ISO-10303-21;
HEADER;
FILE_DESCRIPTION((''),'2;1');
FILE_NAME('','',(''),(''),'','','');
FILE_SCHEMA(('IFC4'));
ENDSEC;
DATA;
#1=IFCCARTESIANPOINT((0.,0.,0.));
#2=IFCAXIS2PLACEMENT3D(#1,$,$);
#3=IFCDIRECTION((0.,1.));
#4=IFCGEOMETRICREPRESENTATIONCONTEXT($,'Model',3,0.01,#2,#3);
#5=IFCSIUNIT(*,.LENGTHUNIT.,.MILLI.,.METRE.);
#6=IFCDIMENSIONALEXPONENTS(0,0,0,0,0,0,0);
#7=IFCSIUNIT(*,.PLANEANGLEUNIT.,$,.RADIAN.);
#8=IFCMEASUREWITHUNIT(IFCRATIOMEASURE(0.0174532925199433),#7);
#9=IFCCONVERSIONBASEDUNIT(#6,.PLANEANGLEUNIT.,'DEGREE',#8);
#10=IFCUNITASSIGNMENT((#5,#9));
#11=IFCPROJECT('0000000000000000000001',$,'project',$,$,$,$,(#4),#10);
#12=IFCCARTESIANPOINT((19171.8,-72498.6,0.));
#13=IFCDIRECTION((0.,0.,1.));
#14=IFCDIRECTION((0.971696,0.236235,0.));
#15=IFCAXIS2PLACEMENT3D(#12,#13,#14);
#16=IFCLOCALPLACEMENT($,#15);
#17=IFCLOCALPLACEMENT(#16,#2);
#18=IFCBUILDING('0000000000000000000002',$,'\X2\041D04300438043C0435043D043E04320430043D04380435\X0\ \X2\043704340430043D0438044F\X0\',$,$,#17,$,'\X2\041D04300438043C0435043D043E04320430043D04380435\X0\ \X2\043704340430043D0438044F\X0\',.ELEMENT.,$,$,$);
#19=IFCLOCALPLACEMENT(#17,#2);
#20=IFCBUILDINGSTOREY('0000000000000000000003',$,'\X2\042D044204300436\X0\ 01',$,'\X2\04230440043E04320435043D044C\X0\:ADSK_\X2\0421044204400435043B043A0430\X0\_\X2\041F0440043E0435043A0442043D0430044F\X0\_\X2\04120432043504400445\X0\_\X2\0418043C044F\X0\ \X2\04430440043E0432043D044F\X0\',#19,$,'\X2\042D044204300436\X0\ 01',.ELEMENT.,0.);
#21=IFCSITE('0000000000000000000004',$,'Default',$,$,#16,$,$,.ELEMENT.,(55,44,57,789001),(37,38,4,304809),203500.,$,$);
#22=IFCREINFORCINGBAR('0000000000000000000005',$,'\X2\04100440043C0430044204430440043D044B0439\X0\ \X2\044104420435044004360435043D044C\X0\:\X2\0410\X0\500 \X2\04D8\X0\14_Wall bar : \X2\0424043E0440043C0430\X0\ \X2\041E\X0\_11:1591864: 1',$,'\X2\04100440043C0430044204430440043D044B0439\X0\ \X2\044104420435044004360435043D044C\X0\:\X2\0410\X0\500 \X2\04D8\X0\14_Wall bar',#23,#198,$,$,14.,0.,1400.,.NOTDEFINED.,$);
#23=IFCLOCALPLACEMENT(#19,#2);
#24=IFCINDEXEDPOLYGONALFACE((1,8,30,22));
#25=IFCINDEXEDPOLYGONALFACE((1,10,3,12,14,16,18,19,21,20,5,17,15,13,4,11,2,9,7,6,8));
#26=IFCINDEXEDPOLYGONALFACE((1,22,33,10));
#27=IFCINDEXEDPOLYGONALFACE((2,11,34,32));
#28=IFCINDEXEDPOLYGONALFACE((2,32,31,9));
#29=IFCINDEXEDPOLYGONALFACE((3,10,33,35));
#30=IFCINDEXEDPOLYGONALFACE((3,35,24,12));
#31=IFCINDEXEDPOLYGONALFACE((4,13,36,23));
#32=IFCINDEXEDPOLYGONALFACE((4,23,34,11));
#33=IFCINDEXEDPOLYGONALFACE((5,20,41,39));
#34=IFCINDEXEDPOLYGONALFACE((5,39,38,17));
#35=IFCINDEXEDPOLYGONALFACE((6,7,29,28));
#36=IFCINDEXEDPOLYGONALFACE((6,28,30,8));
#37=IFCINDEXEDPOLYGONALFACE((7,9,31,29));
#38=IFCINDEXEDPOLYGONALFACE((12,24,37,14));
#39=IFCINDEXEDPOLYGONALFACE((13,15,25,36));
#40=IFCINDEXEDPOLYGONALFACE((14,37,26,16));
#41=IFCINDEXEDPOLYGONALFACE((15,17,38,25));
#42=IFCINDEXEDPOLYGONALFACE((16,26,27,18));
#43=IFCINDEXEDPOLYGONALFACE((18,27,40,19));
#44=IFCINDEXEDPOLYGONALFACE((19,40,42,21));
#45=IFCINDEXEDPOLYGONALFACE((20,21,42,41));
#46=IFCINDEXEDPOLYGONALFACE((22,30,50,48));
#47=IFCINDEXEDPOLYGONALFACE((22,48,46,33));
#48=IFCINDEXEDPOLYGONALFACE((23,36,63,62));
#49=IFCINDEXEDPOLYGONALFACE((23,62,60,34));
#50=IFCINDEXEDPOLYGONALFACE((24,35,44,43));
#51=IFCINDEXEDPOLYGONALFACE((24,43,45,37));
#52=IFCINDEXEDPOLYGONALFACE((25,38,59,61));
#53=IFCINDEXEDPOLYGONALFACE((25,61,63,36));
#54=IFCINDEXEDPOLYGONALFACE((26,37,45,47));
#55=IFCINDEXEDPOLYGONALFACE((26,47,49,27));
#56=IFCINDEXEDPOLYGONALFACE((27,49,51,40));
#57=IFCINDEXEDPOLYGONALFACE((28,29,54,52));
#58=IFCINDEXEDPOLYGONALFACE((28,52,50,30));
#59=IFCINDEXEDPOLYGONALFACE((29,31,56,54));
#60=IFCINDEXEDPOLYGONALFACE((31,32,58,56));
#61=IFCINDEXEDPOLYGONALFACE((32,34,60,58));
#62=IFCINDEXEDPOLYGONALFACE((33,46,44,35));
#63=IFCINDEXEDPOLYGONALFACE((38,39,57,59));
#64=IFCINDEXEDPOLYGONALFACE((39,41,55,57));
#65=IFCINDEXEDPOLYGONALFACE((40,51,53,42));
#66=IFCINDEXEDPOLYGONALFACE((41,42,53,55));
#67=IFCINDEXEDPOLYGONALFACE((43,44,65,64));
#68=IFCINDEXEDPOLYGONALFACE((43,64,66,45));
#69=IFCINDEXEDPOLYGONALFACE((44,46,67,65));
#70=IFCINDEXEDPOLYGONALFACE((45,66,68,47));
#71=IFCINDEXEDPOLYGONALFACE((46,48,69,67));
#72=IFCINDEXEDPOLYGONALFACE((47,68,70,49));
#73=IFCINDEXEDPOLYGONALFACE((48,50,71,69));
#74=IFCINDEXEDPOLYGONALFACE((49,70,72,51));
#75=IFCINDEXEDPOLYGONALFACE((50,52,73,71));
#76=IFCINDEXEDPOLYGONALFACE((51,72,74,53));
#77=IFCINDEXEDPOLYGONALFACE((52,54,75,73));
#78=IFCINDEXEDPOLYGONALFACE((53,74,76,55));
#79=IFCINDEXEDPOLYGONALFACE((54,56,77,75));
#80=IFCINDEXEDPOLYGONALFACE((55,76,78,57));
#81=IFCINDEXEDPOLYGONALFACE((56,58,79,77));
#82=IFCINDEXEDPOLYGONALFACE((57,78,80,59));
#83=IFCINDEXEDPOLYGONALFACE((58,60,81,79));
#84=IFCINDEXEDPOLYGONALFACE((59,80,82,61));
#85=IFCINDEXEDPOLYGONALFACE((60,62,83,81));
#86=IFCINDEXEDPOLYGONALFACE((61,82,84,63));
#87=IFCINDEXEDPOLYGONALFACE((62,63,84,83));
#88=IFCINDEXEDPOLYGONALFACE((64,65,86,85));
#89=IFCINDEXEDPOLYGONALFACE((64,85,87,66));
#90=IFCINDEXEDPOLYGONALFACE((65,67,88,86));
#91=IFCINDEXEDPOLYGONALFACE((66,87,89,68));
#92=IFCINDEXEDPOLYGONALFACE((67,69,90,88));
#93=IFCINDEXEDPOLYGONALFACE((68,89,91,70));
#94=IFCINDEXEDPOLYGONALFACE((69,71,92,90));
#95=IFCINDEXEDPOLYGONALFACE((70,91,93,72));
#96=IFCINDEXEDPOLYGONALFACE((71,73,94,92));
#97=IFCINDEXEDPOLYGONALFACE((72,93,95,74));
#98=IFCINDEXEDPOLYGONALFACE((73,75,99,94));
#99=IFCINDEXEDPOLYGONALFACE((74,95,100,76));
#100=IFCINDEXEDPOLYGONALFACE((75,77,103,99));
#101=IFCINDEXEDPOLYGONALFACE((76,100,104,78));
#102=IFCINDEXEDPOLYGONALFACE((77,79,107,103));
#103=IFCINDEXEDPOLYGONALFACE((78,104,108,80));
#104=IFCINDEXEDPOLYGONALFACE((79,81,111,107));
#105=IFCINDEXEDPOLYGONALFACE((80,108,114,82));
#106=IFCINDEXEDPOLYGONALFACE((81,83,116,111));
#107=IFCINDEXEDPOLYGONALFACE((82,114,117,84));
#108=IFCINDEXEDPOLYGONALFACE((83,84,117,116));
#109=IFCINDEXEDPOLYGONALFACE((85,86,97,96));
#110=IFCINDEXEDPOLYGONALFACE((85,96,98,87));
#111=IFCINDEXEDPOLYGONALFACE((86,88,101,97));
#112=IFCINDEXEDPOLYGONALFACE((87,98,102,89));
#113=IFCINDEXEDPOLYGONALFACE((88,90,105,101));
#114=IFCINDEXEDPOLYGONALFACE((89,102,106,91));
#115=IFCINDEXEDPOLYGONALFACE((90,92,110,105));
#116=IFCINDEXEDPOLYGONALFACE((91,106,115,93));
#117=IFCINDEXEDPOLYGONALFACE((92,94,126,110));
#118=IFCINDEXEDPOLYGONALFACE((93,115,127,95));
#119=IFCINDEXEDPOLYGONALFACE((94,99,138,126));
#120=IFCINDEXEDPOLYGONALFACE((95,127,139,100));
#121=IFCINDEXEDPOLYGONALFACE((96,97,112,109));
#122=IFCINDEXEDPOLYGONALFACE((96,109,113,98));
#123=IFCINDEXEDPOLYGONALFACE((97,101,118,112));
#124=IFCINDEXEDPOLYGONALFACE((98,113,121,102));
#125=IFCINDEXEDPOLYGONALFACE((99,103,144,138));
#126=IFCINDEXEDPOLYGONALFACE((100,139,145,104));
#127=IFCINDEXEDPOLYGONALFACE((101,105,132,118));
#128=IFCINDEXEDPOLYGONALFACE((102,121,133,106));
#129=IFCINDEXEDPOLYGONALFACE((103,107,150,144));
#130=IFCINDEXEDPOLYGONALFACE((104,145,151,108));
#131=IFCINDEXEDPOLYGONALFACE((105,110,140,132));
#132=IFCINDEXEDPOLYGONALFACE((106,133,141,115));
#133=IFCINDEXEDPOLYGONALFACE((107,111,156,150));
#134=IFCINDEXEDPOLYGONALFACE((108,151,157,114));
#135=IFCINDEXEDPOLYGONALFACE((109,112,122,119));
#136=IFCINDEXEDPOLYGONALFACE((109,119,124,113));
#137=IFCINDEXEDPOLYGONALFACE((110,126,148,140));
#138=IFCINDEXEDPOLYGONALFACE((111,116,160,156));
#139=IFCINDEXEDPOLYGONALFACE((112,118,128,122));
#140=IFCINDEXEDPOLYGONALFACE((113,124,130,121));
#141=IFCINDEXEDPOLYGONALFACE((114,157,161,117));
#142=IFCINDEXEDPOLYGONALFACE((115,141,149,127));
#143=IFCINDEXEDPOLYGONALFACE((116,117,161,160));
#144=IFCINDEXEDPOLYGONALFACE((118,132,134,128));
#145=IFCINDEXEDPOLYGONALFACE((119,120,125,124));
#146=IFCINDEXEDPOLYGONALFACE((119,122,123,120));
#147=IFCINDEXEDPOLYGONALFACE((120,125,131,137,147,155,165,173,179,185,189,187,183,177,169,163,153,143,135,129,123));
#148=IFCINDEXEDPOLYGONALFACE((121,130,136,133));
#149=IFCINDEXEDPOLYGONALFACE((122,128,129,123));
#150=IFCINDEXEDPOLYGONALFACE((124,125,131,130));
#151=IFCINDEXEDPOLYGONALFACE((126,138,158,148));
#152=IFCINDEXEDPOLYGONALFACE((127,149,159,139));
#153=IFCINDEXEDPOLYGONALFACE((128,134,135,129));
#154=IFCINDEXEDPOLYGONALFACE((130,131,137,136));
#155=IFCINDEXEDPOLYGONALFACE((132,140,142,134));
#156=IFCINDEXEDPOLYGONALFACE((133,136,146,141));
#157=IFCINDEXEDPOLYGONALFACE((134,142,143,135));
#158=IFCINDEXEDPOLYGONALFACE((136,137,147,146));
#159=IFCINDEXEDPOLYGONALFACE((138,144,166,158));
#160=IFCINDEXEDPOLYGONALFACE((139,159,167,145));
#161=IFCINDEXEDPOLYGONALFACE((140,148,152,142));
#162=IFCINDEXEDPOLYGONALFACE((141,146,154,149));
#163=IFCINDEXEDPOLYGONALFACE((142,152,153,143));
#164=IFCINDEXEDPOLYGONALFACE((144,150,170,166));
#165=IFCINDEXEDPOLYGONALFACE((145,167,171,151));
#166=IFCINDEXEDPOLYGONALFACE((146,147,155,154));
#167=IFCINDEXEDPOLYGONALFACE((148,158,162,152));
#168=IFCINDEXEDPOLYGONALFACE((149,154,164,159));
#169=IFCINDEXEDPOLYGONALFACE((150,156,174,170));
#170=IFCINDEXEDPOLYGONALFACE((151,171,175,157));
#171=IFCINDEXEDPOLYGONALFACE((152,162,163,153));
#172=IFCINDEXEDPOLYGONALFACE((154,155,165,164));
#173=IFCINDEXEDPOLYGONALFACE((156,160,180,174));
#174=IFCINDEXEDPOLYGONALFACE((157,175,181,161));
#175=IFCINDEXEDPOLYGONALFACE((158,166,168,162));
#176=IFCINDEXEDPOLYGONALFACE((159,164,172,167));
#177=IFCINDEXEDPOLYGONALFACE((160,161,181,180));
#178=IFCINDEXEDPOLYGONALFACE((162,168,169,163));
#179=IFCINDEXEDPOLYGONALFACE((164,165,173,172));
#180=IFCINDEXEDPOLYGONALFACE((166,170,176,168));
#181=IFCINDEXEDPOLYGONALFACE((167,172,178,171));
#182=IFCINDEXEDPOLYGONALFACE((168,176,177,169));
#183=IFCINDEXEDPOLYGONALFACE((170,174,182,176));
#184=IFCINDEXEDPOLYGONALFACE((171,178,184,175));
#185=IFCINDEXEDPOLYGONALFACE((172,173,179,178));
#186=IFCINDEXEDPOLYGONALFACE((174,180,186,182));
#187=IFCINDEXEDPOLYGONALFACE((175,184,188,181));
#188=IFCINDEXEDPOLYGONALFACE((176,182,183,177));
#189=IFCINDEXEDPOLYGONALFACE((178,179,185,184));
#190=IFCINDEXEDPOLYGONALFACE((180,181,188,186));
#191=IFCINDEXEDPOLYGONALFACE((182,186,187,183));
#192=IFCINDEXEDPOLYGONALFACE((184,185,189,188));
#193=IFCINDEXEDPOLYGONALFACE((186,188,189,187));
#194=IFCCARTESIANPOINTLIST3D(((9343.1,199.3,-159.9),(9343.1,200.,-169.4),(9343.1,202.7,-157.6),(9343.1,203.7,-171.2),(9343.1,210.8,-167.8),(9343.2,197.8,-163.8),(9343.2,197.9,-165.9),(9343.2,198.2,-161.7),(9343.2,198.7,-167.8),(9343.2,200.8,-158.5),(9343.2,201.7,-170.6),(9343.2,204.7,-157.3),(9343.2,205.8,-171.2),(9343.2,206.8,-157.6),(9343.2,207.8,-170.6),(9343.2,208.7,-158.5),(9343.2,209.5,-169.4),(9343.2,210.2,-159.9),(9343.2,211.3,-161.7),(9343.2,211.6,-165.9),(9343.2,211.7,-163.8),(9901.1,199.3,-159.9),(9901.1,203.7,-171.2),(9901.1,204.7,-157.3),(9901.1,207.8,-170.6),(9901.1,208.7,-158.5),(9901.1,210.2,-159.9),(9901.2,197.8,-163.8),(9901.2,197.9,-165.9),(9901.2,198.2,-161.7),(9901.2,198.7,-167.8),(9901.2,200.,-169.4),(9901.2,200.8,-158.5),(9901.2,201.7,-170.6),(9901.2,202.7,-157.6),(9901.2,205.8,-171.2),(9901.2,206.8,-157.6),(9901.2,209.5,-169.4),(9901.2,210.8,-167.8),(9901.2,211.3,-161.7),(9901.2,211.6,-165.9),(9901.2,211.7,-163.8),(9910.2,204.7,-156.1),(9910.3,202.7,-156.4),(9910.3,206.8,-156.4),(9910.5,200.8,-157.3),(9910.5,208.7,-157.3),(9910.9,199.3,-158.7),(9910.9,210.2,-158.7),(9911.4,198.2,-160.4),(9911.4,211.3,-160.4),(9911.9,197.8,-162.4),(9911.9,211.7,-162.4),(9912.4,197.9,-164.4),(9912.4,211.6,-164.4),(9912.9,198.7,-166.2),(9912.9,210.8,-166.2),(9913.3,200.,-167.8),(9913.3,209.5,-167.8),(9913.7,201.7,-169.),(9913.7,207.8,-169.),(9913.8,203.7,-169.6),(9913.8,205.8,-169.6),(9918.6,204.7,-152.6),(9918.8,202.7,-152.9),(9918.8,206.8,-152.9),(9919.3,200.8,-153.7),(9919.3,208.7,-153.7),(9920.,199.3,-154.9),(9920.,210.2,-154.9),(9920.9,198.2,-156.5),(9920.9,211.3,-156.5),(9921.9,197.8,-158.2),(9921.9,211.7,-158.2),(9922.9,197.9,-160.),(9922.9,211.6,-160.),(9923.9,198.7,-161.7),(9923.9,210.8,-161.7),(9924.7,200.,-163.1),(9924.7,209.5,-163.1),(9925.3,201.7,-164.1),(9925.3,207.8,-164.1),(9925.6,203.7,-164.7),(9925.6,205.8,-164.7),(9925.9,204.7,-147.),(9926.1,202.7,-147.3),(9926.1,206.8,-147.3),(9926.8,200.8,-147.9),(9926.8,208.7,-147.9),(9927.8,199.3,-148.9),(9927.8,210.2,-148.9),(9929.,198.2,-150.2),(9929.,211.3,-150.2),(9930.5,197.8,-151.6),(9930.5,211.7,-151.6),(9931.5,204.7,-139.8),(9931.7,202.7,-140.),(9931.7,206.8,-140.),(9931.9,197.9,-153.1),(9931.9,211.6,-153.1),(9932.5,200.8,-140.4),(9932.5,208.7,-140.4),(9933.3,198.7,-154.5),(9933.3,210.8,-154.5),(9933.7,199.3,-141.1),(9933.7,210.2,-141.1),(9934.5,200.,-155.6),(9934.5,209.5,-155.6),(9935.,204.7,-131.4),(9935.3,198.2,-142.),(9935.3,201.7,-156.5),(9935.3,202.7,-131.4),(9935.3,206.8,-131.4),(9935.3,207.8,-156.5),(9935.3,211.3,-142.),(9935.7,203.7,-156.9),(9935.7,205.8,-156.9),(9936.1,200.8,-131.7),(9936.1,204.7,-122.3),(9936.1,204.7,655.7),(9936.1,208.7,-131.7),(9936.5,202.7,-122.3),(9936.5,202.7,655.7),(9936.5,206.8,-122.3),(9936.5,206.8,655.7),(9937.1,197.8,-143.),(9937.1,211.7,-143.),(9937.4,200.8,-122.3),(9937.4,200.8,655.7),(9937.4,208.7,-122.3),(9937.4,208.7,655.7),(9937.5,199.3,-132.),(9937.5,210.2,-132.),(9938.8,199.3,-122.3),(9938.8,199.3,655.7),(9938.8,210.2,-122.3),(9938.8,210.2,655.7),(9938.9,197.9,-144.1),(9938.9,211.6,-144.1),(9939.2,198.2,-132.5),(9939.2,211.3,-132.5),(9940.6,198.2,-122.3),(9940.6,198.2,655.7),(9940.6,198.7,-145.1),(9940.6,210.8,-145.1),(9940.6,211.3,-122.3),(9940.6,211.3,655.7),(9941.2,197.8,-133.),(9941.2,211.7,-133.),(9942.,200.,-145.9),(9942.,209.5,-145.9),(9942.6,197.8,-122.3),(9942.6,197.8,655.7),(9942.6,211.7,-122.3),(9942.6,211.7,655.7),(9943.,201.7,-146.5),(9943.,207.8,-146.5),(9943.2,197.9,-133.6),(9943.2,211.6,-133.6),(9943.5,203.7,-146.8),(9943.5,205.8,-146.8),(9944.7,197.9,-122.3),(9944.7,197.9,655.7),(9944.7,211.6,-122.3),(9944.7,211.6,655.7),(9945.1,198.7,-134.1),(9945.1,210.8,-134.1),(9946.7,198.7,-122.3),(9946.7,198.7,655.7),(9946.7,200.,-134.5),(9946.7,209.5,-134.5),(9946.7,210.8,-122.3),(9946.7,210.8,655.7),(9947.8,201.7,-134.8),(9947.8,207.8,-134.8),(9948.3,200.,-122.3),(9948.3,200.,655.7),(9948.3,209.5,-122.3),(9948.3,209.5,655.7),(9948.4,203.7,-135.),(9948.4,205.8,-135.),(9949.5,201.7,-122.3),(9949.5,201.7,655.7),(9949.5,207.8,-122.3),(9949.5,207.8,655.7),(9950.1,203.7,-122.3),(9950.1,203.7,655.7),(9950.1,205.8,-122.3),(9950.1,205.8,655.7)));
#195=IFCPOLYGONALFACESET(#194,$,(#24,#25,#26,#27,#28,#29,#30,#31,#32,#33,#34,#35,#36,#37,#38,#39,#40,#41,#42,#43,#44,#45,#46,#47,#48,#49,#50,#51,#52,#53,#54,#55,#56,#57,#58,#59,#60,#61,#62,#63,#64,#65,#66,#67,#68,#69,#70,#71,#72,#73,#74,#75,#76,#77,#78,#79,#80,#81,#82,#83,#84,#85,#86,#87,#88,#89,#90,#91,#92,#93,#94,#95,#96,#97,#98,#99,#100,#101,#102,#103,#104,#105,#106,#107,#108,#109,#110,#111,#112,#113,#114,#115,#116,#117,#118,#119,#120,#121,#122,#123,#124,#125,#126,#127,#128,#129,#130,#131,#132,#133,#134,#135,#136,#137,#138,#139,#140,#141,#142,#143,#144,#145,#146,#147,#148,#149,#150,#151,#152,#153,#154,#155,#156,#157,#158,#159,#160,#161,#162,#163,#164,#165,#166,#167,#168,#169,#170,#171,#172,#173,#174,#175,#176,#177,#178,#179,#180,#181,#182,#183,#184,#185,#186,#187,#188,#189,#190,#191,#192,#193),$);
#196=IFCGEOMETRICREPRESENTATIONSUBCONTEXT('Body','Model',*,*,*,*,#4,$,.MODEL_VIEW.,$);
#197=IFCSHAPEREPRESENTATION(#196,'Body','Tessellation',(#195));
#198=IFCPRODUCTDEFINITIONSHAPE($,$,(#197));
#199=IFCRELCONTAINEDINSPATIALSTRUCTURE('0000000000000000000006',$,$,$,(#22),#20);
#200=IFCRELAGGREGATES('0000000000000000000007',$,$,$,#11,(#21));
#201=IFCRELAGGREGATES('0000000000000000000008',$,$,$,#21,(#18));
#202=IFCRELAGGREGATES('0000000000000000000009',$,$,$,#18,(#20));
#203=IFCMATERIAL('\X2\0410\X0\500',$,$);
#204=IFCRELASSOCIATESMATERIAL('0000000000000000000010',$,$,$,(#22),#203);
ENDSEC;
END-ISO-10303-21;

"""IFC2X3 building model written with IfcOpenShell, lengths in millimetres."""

from ifc_helpers import new_model, entity, si_unit, converted_unit, direction, frame, origin, place, context, subcontext, project, spatial, material, element, save


model = new_model("IFC2X3")

# Units and contexts
model_context = context("Model", 3, precision=0.01, world=origin(), true_north=direction((0.0, 1.0)))
body_context = subcontext(model_context, "Body", "Model", "MODEL_VIEW")
ifc_project = project(units=[si_unit("LENGTHUNIT", "METRE", prefix="MILLI"), converted_unit("PLANEANGLEUNIT", "DEGREE", entity("IfcRatioMeasure", 0.0174532925199433), si_unit("PLANEANGLEUNIT", "RADIAN"), dimensions=[0, 0, 0, 0, 0, 0, 0])], contexts=[model_context])

# Site, building, storey
site_placement = place(None, frame((19171.8, -72498.6, 0.0), z_axis=(0.0, 0.0, 1.0), x_axis=(0.971696, 0.236235, 0.0)))
site = spatial("IfcSite", under=ifc_project, at=site_placement, Name="Default", CompositionType="ELEMENT", RefLatitude=(55, 44, 57, 789001), RefLongitude=(37, 38, 4, 304809), RefElevation=203500.0)
building_placement = place(site_placement, origin())
building = spatial("IfcBuilding", under=site, at=building_placement, Name="Наименование здания", LongName="Наименование здания", CompositionType="ELEMENT")
storey_placement = place(building_placement, origin())
storey = spatial("IfcBuildingStorey", under=building, at=storey_placement, Name="Этаж 01", ObjectType="Уровень:ADSK_Стрелка_Проектная_Вверх_Имя уровня", LongName="Этаж 01", CompositionType="ELEMENT", Elevation=0.0)

# Reinforcing bar
ifc_material = material(Name="А500")
placement = place(storey_placement, origin())
element("IfcReinforcingBar", 1, at=placement, inside=storey, material=ifc_material, Name="Арматурный стержень:А500 Ә14_Wall bar : Форма О_11:1591864: 1", ObjectType="Арматурный стержень:А500 Ә14_Wall bar", BarLength=1400.0, BarRole="NOTDEFINED", CrossSectionArea=0.0, NominalDiameter=14.0, context=body_context, shape_type="AdvancedSweptSolid", body=[
    entity("IfcSweptDiskSolid", entity("IfcCompositeCurve", [entity("IfcCompositeCurveSegment", "CONTINUOUS", True, entity("IfcPolyline", [entity("IfcCartesianPoint", [9943.1, 204.7, 655.7]), entity("IfcCartesianPoint", [9943.1, 204.7, -122.3])])), entity("IfcCompositeCurveSegment", "CONTINUOUS", True, entity("IfcTrimmedCurve", entity("IfcCircle", entity("IfcAxis2Placement3D", entity("IfcCartesianPoint", [9901.1, 204.7, -122.3]), entity("IfcDirection", [0.0, 1.0, 0.0]), entity("IfcDirection", [0.0, 0.0, -1.0])), 42.0), [entity("IfcParameterValue", 270.0)], [entity("IfcParameterValue", 360.0)], True, "PARAMETER")), entity("IfcCompositeCurveSegment", "CONTINUOUS", True, entity("IfcPolyline", [entity("IfcCartesianPoint", [9901.1, 204.7, -164.3]), entity("IfcCartesianPoint", [9343.1, 204.7, -164.3])]))], False), 7.0, None, 0.0, 92.0),
])

save(model, "model.ifc")
